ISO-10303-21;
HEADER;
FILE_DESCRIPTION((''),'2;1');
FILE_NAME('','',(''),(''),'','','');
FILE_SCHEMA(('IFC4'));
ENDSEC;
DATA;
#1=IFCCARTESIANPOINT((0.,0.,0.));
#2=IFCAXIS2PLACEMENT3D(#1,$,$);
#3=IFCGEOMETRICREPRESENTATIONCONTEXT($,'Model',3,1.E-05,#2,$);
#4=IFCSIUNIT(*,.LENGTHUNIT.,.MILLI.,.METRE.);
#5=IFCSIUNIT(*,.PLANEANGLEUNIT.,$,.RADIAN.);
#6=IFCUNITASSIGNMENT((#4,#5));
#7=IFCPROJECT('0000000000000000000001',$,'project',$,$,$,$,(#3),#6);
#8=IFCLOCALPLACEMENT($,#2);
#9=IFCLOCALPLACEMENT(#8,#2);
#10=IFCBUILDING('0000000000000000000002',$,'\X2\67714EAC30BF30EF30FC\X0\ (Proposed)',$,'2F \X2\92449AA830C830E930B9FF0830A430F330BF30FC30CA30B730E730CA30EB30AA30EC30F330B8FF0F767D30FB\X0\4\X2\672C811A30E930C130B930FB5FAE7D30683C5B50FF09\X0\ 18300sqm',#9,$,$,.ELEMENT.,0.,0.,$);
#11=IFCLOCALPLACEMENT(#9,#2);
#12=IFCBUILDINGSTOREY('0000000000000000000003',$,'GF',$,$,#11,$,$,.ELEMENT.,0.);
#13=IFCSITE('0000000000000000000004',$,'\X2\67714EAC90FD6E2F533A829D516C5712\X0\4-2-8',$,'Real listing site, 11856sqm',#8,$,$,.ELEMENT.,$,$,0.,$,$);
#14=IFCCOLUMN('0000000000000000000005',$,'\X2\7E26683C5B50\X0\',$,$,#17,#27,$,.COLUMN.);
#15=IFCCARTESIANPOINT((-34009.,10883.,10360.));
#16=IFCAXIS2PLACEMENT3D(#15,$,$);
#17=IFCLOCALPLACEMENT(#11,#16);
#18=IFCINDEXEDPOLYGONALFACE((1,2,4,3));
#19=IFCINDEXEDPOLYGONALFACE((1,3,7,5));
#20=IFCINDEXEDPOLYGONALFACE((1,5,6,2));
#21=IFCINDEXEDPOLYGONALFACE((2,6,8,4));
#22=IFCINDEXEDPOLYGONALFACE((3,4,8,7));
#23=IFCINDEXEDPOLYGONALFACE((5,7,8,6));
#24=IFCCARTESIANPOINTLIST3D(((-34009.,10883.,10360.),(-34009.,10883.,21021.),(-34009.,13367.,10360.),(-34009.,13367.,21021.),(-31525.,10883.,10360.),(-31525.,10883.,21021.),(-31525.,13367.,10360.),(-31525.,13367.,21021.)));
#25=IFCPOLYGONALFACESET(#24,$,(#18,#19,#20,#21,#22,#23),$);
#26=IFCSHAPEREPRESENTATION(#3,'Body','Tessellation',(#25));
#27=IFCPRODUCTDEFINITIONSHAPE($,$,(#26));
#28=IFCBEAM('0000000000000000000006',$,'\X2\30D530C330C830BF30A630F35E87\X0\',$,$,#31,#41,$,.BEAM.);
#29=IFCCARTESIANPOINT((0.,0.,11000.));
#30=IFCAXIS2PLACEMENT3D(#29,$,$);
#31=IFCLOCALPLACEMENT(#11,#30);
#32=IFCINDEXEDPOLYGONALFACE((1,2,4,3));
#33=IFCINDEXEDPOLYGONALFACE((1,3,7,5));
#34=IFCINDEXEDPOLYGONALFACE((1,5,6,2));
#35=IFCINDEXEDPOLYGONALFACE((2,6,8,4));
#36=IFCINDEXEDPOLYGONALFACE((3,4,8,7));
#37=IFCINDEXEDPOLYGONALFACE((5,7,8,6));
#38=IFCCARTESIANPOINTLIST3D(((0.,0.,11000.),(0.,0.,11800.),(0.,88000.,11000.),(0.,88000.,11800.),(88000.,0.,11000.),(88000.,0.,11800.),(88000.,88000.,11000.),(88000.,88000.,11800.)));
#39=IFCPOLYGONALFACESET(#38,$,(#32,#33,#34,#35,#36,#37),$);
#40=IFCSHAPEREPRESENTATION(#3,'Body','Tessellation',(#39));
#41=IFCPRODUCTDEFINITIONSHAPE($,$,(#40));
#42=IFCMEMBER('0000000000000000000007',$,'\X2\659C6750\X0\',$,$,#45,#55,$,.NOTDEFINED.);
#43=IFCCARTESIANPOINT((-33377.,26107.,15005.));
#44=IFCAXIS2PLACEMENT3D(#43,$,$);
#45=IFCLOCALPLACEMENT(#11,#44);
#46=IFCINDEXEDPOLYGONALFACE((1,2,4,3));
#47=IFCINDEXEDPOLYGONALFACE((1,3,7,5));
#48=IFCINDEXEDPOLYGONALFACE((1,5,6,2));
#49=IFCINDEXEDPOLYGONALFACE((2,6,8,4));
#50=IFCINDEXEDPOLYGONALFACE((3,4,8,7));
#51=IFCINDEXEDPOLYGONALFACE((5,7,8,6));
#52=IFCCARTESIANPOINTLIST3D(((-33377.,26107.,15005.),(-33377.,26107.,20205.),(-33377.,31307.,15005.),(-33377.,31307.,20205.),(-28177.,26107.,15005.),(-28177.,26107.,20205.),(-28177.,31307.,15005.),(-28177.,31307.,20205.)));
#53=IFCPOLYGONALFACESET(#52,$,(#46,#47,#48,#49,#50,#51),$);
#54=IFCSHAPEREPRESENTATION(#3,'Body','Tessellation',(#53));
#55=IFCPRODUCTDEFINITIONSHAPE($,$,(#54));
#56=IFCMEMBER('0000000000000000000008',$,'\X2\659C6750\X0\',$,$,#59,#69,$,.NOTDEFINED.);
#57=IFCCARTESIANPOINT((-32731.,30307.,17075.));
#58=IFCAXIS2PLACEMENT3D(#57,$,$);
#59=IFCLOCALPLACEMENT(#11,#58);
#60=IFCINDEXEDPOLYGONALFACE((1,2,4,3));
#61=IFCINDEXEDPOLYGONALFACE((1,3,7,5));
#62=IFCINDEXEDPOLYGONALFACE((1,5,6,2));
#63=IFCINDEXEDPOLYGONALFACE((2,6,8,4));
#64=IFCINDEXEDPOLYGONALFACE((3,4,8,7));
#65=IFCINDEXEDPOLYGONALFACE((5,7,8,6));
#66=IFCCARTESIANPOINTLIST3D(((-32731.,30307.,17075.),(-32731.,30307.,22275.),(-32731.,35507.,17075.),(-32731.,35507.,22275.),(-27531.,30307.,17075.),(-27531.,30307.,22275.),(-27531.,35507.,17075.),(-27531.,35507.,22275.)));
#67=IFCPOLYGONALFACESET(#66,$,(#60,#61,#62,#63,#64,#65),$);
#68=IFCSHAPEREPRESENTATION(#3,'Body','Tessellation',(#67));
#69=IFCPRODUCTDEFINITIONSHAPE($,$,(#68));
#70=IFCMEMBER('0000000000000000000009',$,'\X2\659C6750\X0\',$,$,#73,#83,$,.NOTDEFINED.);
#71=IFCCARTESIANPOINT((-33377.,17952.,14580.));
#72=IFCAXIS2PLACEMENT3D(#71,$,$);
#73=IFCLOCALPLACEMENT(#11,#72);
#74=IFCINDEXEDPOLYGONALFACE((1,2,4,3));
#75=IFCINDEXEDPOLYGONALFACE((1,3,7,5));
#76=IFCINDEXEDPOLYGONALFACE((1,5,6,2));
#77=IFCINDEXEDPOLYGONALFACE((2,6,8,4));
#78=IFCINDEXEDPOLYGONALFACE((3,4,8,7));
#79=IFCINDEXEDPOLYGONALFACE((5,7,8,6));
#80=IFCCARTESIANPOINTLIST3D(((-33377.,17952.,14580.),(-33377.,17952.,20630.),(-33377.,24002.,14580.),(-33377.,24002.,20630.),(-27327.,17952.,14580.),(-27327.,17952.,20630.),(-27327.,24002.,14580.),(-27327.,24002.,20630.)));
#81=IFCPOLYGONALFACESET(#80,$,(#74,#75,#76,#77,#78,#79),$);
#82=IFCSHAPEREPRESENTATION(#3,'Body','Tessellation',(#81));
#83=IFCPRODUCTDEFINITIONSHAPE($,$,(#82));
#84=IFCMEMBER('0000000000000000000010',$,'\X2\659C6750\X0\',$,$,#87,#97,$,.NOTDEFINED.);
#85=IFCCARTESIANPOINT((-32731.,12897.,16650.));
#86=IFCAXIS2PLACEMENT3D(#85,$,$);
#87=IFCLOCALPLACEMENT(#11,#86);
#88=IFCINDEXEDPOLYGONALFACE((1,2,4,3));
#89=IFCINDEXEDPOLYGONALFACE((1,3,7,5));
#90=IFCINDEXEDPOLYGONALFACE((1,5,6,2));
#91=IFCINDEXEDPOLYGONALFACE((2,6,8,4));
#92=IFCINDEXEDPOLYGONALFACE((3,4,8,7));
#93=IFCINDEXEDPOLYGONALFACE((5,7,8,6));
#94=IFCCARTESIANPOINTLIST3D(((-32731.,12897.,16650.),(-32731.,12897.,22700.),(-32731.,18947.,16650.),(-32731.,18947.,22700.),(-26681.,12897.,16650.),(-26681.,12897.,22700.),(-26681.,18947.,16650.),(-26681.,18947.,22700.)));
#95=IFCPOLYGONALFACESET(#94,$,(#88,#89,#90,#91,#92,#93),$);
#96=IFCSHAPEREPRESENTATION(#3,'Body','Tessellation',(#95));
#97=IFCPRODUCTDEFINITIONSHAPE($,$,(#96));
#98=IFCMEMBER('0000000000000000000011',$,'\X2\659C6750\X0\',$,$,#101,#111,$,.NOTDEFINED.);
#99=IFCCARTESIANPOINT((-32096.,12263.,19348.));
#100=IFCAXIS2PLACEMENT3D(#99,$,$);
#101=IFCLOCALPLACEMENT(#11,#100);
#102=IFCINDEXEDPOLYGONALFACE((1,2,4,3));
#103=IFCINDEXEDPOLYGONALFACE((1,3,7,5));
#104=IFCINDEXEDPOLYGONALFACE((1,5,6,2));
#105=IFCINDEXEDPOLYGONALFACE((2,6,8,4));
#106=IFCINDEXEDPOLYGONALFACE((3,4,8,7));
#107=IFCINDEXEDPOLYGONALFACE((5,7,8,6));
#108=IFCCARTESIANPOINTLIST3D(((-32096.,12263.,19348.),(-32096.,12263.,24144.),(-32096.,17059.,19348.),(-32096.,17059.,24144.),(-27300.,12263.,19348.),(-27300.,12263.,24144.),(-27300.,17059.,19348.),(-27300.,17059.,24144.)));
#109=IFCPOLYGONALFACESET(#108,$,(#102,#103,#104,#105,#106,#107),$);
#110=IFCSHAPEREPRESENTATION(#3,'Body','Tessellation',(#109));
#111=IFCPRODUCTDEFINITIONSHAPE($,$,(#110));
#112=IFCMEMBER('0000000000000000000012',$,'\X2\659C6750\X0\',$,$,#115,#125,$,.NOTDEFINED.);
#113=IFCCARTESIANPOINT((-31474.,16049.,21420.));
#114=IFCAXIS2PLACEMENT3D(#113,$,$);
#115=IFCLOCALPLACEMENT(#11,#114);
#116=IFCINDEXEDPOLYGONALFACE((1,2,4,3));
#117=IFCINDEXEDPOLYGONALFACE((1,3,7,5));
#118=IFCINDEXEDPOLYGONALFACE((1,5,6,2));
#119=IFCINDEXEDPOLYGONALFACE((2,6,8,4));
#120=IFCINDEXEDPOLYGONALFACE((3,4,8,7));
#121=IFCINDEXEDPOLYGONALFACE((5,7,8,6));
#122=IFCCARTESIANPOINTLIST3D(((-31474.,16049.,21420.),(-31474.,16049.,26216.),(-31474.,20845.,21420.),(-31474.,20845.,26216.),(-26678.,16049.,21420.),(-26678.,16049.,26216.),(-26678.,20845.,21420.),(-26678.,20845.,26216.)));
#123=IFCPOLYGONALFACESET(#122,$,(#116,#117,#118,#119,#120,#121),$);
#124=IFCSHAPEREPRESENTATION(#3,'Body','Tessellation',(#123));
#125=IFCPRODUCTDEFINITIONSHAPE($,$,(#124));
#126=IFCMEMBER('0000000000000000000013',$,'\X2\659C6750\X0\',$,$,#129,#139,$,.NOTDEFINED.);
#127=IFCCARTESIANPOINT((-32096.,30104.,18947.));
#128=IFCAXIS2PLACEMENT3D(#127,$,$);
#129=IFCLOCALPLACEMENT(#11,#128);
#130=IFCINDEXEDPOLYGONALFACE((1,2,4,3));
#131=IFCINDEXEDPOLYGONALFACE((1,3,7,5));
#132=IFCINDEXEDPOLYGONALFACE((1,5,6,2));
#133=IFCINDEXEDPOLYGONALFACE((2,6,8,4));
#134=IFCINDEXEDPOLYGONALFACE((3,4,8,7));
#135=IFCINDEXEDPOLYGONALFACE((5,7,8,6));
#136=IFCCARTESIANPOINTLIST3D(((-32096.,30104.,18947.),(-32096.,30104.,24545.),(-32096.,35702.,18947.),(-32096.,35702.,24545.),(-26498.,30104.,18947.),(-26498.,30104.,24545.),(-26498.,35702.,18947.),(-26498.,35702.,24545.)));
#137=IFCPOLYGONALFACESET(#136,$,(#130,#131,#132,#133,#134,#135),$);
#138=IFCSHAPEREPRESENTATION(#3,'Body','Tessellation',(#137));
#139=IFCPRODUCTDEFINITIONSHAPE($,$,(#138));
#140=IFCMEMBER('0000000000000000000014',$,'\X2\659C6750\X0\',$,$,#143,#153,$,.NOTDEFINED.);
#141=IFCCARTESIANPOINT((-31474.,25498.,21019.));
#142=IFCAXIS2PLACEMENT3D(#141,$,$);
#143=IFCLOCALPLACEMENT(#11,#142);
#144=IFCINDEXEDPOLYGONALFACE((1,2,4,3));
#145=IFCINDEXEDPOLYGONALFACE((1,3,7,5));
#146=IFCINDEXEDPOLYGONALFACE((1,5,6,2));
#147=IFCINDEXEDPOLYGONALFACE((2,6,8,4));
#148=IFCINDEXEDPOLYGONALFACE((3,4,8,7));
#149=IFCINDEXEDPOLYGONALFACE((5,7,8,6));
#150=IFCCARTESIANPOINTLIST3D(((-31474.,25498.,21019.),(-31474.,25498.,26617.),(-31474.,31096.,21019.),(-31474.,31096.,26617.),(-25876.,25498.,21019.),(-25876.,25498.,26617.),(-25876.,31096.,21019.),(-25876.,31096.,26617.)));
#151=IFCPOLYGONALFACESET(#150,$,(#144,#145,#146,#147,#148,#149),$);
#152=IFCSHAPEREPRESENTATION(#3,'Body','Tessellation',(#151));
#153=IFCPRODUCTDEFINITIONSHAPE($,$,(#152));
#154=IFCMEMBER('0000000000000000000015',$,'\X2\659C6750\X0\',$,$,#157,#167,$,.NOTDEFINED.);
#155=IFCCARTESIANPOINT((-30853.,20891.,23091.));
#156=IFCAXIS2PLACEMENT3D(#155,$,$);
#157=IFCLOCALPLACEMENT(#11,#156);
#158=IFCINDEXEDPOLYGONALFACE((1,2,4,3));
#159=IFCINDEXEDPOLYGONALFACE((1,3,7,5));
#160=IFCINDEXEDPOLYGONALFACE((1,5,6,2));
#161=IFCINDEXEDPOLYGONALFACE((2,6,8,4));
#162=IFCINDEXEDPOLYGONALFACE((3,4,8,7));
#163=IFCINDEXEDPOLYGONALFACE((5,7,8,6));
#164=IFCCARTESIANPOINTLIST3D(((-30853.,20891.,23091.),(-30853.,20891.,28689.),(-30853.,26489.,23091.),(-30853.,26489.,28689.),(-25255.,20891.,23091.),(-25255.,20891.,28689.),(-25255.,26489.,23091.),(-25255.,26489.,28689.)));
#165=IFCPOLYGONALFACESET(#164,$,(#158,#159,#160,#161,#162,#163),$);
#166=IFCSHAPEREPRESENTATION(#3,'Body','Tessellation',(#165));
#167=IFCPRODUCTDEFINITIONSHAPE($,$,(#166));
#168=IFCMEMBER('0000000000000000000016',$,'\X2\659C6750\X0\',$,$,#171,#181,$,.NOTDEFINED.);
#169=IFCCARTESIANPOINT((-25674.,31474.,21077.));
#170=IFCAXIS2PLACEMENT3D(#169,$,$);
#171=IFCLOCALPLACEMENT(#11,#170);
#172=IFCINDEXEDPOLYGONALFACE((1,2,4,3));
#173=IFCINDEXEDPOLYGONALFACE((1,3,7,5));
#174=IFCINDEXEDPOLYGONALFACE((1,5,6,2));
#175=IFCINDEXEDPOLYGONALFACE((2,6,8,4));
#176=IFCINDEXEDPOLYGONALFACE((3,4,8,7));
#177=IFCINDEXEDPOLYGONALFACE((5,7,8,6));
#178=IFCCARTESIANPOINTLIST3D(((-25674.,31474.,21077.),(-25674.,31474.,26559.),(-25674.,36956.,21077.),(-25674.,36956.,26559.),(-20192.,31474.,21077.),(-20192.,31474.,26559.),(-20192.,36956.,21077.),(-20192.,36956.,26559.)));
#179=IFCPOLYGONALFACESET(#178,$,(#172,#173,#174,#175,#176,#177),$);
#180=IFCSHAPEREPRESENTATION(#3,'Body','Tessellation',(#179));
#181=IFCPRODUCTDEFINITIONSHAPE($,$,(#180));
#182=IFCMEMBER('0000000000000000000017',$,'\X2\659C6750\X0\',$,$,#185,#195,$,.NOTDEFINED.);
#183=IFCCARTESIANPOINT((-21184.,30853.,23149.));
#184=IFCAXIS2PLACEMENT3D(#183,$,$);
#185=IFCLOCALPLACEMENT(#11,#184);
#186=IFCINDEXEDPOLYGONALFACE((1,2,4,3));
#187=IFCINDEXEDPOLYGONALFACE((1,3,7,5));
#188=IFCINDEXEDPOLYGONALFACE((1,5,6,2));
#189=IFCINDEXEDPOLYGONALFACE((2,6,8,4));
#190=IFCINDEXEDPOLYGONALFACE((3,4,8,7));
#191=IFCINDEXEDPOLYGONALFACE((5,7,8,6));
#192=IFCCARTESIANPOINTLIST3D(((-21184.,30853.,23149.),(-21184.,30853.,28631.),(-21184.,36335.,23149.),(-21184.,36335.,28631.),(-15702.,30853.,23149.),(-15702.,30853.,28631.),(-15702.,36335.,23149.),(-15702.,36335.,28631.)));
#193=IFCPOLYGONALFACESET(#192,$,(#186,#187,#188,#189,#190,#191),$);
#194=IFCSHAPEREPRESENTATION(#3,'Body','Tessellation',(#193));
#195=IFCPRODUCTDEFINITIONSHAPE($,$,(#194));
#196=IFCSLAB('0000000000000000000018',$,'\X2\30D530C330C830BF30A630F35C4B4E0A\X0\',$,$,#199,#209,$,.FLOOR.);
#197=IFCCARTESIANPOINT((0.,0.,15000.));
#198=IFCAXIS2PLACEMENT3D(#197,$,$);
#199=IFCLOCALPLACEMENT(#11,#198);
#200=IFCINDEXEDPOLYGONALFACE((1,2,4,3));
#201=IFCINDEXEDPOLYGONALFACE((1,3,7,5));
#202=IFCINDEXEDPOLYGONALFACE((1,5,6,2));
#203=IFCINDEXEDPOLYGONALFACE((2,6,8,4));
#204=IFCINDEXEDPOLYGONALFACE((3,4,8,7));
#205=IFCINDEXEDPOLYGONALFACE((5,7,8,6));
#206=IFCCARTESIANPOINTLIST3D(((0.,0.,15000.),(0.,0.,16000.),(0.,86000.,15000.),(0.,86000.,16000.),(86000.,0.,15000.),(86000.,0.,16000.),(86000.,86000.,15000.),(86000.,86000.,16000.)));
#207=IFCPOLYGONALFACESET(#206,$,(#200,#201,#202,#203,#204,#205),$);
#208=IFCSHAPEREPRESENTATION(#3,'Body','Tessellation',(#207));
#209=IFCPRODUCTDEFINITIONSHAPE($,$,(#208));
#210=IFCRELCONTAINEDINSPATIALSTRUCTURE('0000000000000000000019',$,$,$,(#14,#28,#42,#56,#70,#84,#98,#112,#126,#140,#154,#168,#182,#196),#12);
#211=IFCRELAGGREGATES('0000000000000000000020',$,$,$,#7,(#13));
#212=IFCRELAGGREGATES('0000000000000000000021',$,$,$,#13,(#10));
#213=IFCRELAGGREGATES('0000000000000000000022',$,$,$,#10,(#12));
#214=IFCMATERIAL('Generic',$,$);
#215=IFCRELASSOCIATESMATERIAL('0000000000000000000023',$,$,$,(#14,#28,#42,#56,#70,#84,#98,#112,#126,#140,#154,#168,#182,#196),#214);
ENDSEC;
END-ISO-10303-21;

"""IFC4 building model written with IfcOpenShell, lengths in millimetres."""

from ifc_helpers import new_model, si_unit, frame, frame_2d, origin, place, context, project, spatial, rectangle, extrude, material, element, save


model = new_model("IFC4")

# Units and contexts
model_context = context("Model", 3, precision=1e-05, world=origin())
ifc_project = project(units=[si_unit("LENGTHUNIT", "METRE", prefix="MILLI"), si_unit("PLANEANGLEUNIT", "RADIAN")], contexts=[model_context])

# Site, building, storey
site_placement = place(None, origin())
site = spatial("IfcSite", under=ifc_project, at=site_placement, Name="東京都港区芝公園4-2-8", ObjectType="Real listing site, 11856sqm", CompositionType="ELEMENT", RefElevation=0.0)
building_placement = place(site_placement, origin())
building = spatial("IfcBuilding", under=site, at=building_placement, Name="東京タワー (Proposed)", ObjectType="2F 鉄骨トラス（インターナショナルオレンジ／白・4本脚ラチス・微細格子） 18300sqm", CompositionType="ELEMENT", ElevationOfRefHeight=0.0, ElevationOfTerrain=0.0)
storey_placement = place(building_placement, origin())
storey = spatial("IfcBuildingStorey", under=building, at=storey_placement, Name="GF", CompositionType="ELEMENT", Elevation=0.0)

# Column
ifc_material = material(Name="Generic")
column_1_placement = place(storey_placement, frame((-34009.0, 10883.0, 10360.0)))
element("IfcColumn", 1, at=column_1_placement, inside=storey, material=ifc_material, Name="縦格子", PredefinedType="COLUMN", context=model_context, shape_type="SweptSolid", body=[
    extrude(rectangle(XDim=2484.0, YDim=2484.0, at=frame_2d((1242.0, 1242.0))), frame((-34009.0, 10883.0, 10360.0)), (0.0, 0.0, 1.0), 10661.0),
])

# Beam
beam_placement = place(storey_placement, frame((0.0, 0.0, 11000.0)))
element("IfcBeam", 2, at=beam_placement, inside=storey, material=ifc_material, Name="フットタウン庇", PredefinedType="BEAM", context=model_context, shape_type="SweptSolid", body=[
    extrude(rectangle(XDim=88000.0, YDim=88000.0, at=frame_2d((44000.0, 44000.0))), frame((0.0, 0.0, 11000.0)), (0.0, 0.0, 1.0), 800.0),
])

# Members
member_1_placement = place(storey_placement, frame((-33377.0, 26107.0, 15005.0)))
element("IfcMember", 3, at=member_1_placement, inside=storey, material=ifc_material, Name="斜材", PredefinedType="NOTDEFINED", context=model_context, shape_type="SweptSolid", body=[
    extrude(rectangle(XDim=5200.0, YDim=5200.0, at=frame_2d((2600.0, 2600.0))), frame((-33377.0, 26107.0, 15005.0)), (0.0, 0.0, 1.0), 5200.0),
])
member_2_placement = place(storey_placement, frame((-32731.0, 30307.0, 17075.0)))
element("IfcMember", 4, at=member_2_placement, inside=storey, material=ifc_material, Name="斜材", PredefinedType="NOTDEFINED", context=model_context, shape_type="SweptSolid", body=[
    extrude(rectangle(XDim=5200.0, YDim=5200.0, at=frame_2d((2600.0, 2600.0))), frame((-32731.0, 30307.0, 17075.0)), (0.0, 0.0, 1.0), 5200.0),
])
member_3_placement = place(storey_placement, frame((-33377.0, 17952.0, 14580.0)))
element("IfcMember", 5, at=member_3_placement, inside=storey, material=ifc_material, Name="斜材", PredefinedType="NOTDEFINED", context=model_context, shape_type="SweptSolid", body=[
    extrude(rectangle(XDim=6050.0, YDim=6050.0, at=frame_2d((3025.0, 3025.0))), frame((-33377.0, 17952.0, 14580.0)), (0.0, 0.0, 1.0), 6050.0),
])
member_4_placement = place(storey_placement, frame((-32731.0, 12897.0, 16650.0)))
element("IfcMember", 6, at=member_4_placement, inside=storey, material=ifc_material, Name="斜材", PredefinedType="NOTDEFINED", context=model_context, shape_type="SweptSolid", body=[
    extrude(rectangle(XDim=6050.0, YDim=6050.0, at=frame_2d((3025.0, 3025.0))), frame((-32731.0, 12897.0, 16650.0)), (0.0, 0.0, 1.0), 6050.0),
])
member_5_placement = place(storey_placement, frame((-32096.0, 12263.0, 19348.0)))
element("IfcMember", 7, at=member_5_placement, inside=storey, material=ifc_material, Name="斜材", PredefinedType="NOTDEFINED", context=model_context, shape_type="SweptSolid", body=[
    extrude(rectangle(XDim=4796.0, YDim=4796.0, at=frame_2d((2398.0, 2398.0))), frame((-32096.0, 12263.0, 19348.0)), (0.0, 0.0, 1.0), 4796.0),
])
member_6_placement = place(storey_placement, frame((-31474.0, 16049.0, 21420.0)))
element("IfcMember", 8, at=member_6_placement, inside=storey, material=ifc_material, Name="斜材", PredefinedType="NOTDEFINED", context=model_context, shape_type="SweptSolid", body=[
    extrude(rectangle(XDim=4796.0, YDim=4796.0, at=frame_2d((2398.0, 2398.0))), frame((-31474.0, 16049.0, 21420.0)), (0.0, 0.0, 1.0), 4796.0),
])
member_7_placement = place(storey_placement, frame((-32096.0, 30104.0, 18947.0)))
element("IfcMember", 9, at=member_7_placement, inside=storey, material=ifc_material, Name="斜材", PredefinedType="NOTDEFINED", context=model_context, shape_type="SweptSolid", body=[
    extrude(rectangle(XDim=5598.0, YDim=5598.0, at=frame_2d((2799.0, 2799.0))), frame((-32096.0, 30104.0, 18947.0)), (0.0, 0.0, 1.0), 5598.0),
])
member_8_placement = place(storey_placement, frame((-31474.0, 25498.0, 21019.0)))
element("IfcMember", 10, at=member_8_placement, inside=storey, material=ifc_material, Name="斜材", PredefinedType="NOTDEFINED", context=model_context, shape_type="SweptSolid", body=[
    extrude(rectangle(XDim=5598.0, YDim=5598.0, at=frame_2d((2799.0, 2799.0))), frame((-31474.0, 25498.0, 21019.0)), (0.0, 0.0, 1.0), 5598.0),
])
member_9_placement = place(storey_placement, frame((-30853.0, 20891.0, 23091.0)))
element("IfcMember", 11, at=member_9_placement, inside=storey, material=ifc_material, Name="斜材", PredefinedType="NOTDEFINED", context=model_context, shape_type="SweptSolid", body=[
    extrude(rectangle(XDim=5598.0, YDim=5598.0, at=frame_2d((2799.0, 2799.0))), frame((-30853.0, 20891.0, 23091.0)), (0.0, 0.0, 1.0), 5598.0),
])
member_10_placement = place(storey_placement, frame((-25674.0, 31474.0, 21077.0)))
element("IfcMember", 12, at=member_10_placement, inside=storey, material=ifc_material, Name="斜材", PredefinedType="NOTDEFINED", context=model_context, shape_type="SweptSolid", body=[
    extrude(rectangle(XDim=5482.0, YDim=5482.0, at=frame_2d((2741.0, 2741.0))), frame((-25674.0, 31474.0, 21077.0)), (0.0, 0.0, 1.0), 5482.0),
])
member_11_placement = place(storey_placement, frame((-21184.0, 30853.0, 23149.0)))
element("IfcMember", 13, at=member_11_placement, inside=storey, material=ifc_material, Name="斜材", PredefinedType="NOTDEFINED", context=model_context, shape_type="SweptSolid", body=[
    extrude(rectangle(XDim=5482.0, YDim=5482.0, at=frame_2d((2741.0, 2741.0))), frame((-21184.0, 30853.0, 23149.0)), (0.0, 0.0, 1.0), 5482.0),
])

# Slab
slab_placement = place(storey_placement, frame((0.0, 0.0, 15000.0)))
element("IfcSlab", 14, at=slab_placement, inside=storey, material=ifc_material, Name="フットタウン屋上", PredefinedType="FLOOR", context=model_context, shape_type="SweptSolid", body=[
    extrude(rectangle(XDim=86000.0, YDim=86000.0, at=frame_2d((43000.0, 43000.0))), frame((0.0, 0.0, 15000.0)), (0.0, 0.0, 1.0), 1000.0),
])

save(model, "model.ifc")
